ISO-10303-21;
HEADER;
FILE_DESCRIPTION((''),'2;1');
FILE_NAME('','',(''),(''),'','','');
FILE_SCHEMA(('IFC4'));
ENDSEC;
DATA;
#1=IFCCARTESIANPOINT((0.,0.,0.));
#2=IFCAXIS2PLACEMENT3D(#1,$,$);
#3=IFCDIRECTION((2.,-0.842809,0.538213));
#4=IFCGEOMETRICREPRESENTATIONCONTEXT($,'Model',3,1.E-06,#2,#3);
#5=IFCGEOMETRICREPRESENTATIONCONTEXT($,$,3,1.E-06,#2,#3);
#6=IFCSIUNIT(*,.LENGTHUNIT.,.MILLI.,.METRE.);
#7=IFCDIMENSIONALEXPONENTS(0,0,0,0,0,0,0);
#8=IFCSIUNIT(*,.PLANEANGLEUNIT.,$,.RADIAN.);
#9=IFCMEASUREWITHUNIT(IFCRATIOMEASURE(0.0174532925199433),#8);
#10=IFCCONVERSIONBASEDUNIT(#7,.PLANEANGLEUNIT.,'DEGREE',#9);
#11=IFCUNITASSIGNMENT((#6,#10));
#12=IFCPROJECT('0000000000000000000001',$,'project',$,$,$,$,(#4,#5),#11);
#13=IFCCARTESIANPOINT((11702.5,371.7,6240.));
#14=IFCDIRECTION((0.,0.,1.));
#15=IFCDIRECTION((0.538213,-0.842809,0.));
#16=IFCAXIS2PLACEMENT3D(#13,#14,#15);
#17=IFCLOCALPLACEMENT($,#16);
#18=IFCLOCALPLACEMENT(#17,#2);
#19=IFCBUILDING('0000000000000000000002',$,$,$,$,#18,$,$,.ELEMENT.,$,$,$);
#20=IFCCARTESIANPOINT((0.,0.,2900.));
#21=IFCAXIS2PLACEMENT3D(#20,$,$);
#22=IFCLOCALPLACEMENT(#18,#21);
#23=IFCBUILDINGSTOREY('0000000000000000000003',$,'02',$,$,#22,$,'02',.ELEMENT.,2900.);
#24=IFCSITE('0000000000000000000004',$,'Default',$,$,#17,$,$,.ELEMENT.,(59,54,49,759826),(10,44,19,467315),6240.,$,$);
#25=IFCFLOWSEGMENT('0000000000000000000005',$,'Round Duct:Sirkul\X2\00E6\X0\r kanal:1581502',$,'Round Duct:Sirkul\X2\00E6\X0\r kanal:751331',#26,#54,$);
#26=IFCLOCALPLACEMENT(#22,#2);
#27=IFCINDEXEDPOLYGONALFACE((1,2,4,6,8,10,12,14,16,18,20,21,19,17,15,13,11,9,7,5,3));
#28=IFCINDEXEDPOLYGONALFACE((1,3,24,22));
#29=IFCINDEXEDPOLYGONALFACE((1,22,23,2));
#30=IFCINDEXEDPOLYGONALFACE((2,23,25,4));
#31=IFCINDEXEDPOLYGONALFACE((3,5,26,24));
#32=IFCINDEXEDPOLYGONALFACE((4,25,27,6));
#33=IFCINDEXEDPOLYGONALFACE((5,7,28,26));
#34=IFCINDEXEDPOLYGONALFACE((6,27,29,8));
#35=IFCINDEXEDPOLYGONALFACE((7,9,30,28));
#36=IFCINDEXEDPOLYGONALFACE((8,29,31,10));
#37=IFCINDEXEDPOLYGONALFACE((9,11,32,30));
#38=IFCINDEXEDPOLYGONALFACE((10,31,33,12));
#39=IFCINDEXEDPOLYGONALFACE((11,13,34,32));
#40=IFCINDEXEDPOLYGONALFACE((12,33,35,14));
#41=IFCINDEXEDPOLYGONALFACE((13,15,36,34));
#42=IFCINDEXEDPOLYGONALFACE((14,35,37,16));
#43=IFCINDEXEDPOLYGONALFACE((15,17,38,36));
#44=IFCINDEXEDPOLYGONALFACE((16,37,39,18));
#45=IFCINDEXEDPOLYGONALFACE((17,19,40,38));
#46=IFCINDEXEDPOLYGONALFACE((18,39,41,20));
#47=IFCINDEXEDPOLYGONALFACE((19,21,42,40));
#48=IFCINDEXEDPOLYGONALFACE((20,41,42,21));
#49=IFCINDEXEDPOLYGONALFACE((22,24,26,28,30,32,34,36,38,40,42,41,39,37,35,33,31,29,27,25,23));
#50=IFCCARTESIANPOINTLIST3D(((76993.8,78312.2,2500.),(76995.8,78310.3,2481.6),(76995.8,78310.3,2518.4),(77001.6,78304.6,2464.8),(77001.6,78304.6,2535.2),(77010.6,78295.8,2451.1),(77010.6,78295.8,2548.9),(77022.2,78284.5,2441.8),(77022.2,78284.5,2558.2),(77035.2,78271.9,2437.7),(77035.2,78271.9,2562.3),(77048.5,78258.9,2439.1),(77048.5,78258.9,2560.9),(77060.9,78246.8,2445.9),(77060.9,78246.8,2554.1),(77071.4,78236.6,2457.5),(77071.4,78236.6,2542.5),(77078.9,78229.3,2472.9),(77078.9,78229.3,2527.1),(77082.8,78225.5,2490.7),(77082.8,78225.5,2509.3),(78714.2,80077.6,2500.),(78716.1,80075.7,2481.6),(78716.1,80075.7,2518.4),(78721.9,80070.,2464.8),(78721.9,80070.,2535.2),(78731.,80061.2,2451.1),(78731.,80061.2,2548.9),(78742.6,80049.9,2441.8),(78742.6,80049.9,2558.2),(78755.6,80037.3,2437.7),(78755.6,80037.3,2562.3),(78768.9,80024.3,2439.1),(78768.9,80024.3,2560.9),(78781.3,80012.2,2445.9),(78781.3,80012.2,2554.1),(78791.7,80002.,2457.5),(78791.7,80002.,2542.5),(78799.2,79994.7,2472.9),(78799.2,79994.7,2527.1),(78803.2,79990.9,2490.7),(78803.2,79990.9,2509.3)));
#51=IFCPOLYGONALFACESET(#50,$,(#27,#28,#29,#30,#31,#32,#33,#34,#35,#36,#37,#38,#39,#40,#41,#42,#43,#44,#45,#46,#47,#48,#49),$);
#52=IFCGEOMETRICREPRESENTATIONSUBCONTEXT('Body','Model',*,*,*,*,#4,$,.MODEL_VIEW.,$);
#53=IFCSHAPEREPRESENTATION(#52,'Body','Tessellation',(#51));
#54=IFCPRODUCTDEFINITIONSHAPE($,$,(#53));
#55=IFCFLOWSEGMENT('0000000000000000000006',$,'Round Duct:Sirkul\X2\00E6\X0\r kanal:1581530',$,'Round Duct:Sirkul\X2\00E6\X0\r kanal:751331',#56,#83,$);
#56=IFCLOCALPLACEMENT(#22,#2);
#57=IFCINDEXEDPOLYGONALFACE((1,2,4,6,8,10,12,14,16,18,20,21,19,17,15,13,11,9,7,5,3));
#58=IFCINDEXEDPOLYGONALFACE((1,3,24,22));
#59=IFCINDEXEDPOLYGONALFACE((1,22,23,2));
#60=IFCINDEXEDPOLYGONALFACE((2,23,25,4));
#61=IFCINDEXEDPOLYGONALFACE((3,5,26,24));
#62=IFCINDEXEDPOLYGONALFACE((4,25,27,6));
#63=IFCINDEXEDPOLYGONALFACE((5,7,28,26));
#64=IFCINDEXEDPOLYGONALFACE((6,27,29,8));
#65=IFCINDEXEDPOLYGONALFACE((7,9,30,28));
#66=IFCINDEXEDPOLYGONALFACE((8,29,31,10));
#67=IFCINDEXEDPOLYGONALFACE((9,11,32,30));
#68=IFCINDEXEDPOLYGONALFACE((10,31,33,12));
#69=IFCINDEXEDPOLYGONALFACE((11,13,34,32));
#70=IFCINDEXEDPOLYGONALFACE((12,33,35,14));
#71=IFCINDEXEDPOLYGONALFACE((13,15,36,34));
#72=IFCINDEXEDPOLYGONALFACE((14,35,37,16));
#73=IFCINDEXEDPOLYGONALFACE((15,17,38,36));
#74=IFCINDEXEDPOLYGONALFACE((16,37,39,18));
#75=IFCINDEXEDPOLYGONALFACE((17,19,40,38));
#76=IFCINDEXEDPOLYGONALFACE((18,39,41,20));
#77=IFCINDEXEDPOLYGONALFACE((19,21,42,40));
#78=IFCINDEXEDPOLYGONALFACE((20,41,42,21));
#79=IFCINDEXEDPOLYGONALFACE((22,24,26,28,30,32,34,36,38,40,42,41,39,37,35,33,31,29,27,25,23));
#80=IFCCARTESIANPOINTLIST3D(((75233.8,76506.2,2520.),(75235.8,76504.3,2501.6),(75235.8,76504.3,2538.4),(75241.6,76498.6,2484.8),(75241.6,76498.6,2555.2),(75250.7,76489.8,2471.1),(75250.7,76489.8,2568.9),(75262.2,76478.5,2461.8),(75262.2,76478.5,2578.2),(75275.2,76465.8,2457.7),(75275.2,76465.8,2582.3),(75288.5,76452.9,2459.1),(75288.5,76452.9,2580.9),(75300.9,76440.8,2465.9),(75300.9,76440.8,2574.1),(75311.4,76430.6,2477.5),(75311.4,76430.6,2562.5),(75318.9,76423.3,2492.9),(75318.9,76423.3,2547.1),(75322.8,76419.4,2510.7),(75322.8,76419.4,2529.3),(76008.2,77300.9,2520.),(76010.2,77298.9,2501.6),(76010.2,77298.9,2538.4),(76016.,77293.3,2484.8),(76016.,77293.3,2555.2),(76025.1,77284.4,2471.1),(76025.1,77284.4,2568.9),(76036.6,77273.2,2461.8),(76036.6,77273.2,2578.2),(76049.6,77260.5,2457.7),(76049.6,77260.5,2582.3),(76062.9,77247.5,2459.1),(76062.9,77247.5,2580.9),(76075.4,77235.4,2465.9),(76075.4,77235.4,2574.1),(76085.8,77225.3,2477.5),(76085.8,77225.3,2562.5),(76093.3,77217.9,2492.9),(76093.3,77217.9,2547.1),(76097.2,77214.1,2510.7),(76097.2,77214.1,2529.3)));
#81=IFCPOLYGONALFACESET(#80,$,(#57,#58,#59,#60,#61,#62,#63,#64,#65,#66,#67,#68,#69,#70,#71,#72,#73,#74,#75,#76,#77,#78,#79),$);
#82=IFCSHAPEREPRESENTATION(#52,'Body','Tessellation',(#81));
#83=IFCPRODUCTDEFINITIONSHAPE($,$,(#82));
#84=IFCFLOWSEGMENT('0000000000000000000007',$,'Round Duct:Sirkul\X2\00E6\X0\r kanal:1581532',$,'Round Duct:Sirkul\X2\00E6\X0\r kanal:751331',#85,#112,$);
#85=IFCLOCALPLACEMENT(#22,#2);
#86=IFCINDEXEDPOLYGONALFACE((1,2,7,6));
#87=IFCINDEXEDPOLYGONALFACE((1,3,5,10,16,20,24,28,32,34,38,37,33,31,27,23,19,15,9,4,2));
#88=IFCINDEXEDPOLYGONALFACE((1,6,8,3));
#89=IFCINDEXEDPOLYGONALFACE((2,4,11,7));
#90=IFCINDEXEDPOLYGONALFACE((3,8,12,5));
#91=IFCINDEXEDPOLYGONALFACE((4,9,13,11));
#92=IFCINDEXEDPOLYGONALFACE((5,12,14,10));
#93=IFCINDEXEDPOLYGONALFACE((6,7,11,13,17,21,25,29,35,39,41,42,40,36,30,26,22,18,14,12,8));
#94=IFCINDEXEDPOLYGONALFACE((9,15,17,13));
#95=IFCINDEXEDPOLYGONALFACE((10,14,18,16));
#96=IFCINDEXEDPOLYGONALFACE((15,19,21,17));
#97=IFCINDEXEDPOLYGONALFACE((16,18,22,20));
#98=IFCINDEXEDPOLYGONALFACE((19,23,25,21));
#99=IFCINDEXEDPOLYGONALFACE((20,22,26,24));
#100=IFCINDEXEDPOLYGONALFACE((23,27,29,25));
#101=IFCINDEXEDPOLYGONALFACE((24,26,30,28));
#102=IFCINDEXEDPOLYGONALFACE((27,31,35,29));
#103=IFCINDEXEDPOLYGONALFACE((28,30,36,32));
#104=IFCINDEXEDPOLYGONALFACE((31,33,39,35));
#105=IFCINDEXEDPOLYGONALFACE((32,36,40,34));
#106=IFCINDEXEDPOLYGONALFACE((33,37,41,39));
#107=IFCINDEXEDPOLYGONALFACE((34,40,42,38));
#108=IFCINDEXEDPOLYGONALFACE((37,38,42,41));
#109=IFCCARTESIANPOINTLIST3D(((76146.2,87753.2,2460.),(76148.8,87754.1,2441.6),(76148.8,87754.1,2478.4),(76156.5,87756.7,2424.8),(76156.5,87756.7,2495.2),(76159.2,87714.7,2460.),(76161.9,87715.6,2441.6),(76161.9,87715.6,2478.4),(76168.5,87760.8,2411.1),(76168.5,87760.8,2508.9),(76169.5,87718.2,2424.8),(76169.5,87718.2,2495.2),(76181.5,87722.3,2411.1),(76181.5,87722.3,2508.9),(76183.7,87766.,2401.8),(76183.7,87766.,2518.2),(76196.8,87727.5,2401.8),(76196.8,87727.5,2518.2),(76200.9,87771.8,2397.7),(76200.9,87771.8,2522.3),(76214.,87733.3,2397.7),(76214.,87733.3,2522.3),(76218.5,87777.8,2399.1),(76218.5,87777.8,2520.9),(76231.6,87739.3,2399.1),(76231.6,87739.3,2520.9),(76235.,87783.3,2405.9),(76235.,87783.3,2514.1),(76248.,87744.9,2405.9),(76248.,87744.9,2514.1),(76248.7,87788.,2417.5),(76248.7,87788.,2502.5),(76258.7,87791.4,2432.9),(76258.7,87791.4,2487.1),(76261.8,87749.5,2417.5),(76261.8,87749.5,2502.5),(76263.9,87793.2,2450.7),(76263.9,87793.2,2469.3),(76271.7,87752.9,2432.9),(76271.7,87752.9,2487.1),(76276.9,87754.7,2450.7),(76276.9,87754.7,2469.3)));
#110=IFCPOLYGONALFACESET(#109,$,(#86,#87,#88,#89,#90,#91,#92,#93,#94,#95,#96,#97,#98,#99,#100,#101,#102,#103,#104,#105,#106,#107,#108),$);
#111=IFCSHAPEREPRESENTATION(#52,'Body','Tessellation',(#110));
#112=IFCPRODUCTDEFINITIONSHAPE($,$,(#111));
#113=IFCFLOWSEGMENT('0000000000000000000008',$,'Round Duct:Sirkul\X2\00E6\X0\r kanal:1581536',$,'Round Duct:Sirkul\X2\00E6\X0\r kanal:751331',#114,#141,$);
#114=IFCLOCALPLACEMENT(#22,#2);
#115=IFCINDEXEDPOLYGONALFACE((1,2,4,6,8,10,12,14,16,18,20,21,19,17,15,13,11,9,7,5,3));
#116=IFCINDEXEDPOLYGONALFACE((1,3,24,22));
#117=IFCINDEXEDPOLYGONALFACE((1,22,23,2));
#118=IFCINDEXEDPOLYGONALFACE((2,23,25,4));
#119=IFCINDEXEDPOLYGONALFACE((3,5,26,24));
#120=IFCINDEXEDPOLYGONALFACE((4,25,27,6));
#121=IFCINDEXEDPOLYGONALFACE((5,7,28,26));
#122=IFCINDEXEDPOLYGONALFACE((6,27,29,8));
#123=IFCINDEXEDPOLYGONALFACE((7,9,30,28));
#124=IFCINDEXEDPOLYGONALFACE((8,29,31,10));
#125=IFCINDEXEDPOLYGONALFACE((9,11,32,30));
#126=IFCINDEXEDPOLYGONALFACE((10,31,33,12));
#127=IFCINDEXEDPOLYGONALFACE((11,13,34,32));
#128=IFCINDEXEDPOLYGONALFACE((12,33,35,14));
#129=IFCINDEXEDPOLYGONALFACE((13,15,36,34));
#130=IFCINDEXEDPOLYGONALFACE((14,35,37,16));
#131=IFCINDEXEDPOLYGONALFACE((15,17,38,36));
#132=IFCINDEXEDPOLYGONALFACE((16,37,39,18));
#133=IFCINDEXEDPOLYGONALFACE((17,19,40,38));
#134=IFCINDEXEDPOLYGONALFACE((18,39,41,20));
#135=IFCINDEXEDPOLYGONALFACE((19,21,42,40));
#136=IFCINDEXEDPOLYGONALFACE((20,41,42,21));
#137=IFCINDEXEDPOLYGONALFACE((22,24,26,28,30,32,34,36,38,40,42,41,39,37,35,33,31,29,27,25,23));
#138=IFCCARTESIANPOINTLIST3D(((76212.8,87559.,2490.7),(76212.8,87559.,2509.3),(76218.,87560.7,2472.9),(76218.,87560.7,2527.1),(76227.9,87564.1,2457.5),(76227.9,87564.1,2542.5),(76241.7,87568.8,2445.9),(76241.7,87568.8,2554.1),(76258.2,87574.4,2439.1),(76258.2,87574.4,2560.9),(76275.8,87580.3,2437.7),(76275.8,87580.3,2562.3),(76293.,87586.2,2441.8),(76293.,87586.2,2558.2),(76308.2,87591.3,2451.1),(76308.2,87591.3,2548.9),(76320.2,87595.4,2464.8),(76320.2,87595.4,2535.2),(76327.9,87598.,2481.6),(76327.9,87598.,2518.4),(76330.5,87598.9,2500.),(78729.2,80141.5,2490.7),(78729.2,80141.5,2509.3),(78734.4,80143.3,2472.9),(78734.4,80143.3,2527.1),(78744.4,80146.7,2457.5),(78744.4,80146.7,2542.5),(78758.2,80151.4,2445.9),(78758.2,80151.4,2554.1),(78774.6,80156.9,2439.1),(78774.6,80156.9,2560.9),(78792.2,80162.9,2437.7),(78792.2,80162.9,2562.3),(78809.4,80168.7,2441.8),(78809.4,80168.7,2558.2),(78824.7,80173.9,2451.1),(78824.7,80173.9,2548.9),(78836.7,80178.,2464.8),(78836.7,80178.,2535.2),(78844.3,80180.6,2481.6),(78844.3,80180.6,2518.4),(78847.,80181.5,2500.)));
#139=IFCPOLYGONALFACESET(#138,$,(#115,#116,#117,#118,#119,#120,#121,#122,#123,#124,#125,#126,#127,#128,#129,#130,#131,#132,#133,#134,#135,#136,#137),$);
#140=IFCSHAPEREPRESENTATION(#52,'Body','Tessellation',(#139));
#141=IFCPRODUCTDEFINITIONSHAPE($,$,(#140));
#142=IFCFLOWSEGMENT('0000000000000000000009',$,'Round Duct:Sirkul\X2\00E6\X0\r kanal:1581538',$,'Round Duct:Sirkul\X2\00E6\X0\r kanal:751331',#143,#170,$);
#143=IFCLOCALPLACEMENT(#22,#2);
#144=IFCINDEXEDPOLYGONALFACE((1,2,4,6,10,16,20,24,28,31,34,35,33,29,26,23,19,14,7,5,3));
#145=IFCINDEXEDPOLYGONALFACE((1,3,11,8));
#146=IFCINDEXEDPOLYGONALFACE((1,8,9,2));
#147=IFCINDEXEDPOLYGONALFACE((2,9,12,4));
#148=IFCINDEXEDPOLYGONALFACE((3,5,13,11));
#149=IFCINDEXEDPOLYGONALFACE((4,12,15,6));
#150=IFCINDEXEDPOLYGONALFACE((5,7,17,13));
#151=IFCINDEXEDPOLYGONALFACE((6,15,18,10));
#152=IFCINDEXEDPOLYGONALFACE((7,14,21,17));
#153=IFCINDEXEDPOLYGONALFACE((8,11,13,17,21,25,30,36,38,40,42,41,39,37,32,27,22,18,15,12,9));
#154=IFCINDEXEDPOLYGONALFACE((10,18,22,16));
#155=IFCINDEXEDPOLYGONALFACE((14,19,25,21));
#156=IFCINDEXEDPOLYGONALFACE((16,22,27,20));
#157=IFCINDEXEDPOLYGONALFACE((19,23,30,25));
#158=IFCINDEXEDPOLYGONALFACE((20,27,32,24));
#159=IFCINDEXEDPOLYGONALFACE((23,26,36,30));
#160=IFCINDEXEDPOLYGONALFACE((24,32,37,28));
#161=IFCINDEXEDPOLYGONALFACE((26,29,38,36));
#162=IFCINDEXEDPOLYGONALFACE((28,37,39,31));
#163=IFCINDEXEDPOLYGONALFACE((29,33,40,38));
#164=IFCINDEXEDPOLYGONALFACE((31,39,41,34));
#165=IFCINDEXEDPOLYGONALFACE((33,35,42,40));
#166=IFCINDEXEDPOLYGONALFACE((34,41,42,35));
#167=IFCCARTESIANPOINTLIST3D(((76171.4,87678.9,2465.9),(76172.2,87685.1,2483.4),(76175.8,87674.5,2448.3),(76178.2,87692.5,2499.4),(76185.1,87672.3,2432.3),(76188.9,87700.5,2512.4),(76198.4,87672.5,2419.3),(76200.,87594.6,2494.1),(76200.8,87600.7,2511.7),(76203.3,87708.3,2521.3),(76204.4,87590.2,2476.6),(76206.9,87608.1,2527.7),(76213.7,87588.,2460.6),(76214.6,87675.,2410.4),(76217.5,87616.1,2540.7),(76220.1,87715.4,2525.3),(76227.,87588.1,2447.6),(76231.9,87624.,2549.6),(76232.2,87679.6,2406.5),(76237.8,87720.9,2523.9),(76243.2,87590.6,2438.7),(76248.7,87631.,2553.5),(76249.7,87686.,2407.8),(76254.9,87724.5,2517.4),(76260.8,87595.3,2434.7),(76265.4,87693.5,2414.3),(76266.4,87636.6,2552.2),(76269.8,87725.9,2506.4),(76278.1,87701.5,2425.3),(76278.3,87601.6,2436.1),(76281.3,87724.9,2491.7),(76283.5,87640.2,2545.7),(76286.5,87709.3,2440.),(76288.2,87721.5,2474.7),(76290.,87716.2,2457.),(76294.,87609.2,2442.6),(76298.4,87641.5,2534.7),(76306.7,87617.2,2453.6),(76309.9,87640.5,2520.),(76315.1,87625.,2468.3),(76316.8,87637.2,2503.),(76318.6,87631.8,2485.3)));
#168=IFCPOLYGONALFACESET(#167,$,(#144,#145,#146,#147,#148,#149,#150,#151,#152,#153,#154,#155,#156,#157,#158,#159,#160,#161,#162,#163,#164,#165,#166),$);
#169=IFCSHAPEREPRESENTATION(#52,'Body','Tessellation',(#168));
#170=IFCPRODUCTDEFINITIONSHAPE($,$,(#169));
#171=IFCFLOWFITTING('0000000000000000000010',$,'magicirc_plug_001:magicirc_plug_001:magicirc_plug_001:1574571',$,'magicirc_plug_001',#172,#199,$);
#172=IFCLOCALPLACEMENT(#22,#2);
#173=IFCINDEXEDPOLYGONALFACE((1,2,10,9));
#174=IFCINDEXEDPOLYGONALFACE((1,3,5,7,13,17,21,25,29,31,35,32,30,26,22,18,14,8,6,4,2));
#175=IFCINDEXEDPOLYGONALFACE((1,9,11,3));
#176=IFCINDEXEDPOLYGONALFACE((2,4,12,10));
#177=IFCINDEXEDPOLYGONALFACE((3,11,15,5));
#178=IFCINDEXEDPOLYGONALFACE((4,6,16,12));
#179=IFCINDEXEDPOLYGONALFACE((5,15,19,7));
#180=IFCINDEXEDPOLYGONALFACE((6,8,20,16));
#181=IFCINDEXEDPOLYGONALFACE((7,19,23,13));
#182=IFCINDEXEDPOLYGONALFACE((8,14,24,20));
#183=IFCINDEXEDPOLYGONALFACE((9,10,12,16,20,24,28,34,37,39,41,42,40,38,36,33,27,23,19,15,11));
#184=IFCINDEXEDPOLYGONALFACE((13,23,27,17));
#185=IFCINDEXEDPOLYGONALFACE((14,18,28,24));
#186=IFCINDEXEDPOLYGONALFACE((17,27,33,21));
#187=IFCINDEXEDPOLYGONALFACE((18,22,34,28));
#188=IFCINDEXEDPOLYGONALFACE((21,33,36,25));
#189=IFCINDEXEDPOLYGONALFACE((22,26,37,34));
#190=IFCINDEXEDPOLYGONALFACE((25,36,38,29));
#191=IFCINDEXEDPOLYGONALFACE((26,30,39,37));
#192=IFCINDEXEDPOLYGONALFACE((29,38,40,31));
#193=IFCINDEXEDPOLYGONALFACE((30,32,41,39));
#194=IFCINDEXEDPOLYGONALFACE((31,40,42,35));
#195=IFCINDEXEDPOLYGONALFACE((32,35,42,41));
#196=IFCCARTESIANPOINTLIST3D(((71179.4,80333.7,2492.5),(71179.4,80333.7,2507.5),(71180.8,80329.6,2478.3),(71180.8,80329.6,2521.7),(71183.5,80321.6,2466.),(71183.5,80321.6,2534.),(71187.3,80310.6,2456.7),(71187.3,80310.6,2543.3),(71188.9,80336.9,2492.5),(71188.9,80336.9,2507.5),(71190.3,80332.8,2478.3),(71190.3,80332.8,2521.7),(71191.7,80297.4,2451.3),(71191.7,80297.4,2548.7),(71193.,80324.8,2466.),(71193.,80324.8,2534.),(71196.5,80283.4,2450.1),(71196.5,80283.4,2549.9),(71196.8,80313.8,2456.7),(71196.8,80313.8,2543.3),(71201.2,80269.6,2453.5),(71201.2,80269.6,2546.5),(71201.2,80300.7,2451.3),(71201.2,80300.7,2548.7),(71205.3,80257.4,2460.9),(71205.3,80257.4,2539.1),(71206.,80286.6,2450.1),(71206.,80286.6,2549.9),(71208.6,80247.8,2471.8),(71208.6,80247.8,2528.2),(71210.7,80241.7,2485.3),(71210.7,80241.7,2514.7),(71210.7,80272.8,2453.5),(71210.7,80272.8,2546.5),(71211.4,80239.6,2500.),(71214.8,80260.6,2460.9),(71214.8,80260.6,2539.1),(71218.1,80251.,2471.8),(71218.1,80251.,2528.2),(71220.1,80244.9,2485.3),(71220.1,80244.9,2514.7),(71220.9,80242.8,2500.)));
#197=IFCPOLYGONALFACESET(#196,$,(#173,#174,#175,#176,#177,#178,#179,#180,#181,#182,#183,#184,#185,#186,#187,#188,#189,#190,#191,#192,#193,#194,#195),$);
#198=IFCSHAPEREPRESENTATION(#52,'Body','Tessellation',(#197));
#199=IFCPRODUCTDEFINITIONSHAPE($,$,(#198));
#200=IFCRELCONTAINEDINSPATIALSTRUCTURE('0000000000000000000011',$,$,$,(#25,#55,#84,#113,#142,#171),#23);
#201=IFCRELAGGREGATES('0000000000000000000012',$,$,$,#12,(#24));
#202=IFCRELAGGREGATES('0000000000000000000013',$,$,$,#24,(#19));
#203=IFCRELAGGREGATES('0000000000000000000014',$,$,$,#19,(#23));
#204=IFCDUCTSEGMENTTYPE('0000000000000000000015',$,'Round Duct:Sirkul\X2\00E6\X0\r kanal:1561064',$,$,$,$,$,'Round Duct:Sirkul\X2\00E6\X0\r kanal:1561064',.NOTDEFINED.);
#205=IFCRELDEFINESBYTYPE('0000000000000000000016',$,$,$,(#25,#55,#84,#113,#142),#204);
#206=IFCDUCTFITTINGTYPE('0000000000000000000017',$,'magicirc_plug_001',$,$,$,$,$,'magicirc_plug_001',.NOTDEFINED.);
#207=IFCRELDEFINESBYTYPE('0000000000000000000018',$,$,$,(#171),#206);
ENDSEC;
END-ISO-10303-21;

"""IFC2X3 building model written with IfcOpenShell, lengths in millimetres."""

from ifc_helpers import new_model, entity, si_unit, converted_unit, direction, frame, frame_2d, origin, origin_2d_with_axis, place, context, subcontext, project, spatial, circle, extrude, source, transform, mapped, type_object, type_shapes, element, save


model = new_model("IFC2X3")

# Units and contexts
model_context = context("Model", 3, precision=1e-06, world=origin(), true_north=direction((2.0, -0.842809, 0.538213)))
context_of_model = context(None, 3, precision=1e-06, world=origin(), true_north=direction((2.0, -0.842809, 0.538213)))
body_context = subcontext(model_context, "Body", "Model", "MODEL_VIEW")
ifc_project = project(units=[si_unit("LENGTHUNIT", "METRE", prefix="MILLI"), converted_unit("PLANEANGLEUNIT", "DEGREE", entity("IfcRatioMeasure", 0.0174532925199433), si_unit("PLANEANGLEUNIT", "RADIAN"), dimensions=[0, 0, 0, 0, 0, 0, 0])], contexts=[model_context, context_of_model])

# Site, building, storey
site_placement = place(None, frame((11702.5, 371.7, 6240.0), z_axis=(0.0, 0.0, 1.0), x_axis=(0.538213, -0.842809, 0.0)))
site = spatial("IfcSite", under=ifc_project, at=site_placement, Name="Default", CompositionType="ELEMENT", RefLatitude=(59, 54, 49, 759826), RefLongitude=(10, 44, 19, 467315), RefElevation=6240.0)
building_placement = place(site_placement, origin())
building = spatial("IfcBuilding", under=site, at=building_placement, CompositionType="ELEMENT")
storey_placement = place(building_placement, frame((0.0, 0.0, 2900.0)))
storey = spatial("IfcBuildingStorey", under=building, at=storey_placement, Name="02", LongName="02", CompositionType="ELEMENT", Elevation=2900.0)

# Flow segments
duct_segment_type = type_object("IfcDuctSegmentType", Name="Round Duct:Sirkulær kanal:1561064", ElementType="Round Duct:Sirkulær kanal:1561064", PredefinedType="NOTDEFINED")
flow_segment_1_placement = place(storey_placement, origin())
element("IfcFlowSegment", 1, at=flow_segment_1_placement, inside=storey, type_object=duct_segment_type, Name="Round Duct:Sirkulær kanal:1581502", ObjectType="Round Duct:Sirkulær kanal:751331", context=body_context, shape_type="SweptSolid", body=[
    extrude(circle(Radius=62.5, at=frame_2d((0.0, 0.0), x_axis=(1.0, 0.0))), frame((77038.5, 78268.6, 2500.0), z_axis=(0.697915, 0.71618, 0.0), x_axis=(-0.71618, 0.697915, 0.0)), (0.0, 0.0, 1.0), 2465.0),
])
flow_segment_2_placement = place(storey_placement, origin())
element("IfcFlowSegment", 2, at=flow_segment_2_placement, inside=storey, type_object=duct_segment_type, Name="Round Duct:Sirkulær kanal:1581530", ObjectType="Round Duct:Sirkulær kanal:751331", context=body_context, shape_type="SweptSolid", body=[
    extrude(circle(Radius=62.5, at=origin_2d_with_axis()), frame((75278.6, 76462.6, 2520.0), z_axis=(0.697915, 0.71618, 0.0), x_axis=(-0.71618, 0.697915, 0.0)), (0.0, 0.0, 1.0), 1109.6),
])
flow_segment_3_placement = place(storey_placement, origin())
element("IfcFlowSegment", 3, at=flow_segment_3_placement, inside=storey, type_object=duct_segment_type, Name="Round Duct:Sirkulær kanal:1581532", ObjectType="Round Duct:Sirkulær kanal:751331", context=body_context, shape_type="SweptSolid", body=[
    extrude(circle(Radius=62.5, at=origin_2d_with_axis()), frame((76218.4, 87734.8, 2460.0), z_axis=(-0.321245, 0.946996, 0.0), x_axis=(-0.946996, -0.321245, 0.0)), (0.0, 0.0, 1.0), 40.6),
])
flow_segment_4_placement = place(storey_placement, origin())
element("IfcFlowSegment", 4, at=flow_segment_4_placement, inside=storey, type_object=duct_segment_type, Name="Round Duct:Sirkulær kanal:1581536", ObjectType="Round Duct:Sirkulær kanal:751331", context=body_context, shape_type="SweptSolid", body=[
    extrude(circle(Radius=62.5, at=origin_2d_with_axis()), frame((76271.3, 87578.8, 2500.0), z_axis=(0.321274, -0.946986, 0.0), x_axis=(0.946986, 0.321274, 0.0)), (0.0, 0.0, 1.0), 7832.7),
])
flow_segment_5_placement = place(storey_placement, origin())
element("IfcFlowSegment", 5, at=flow_segment_5_placement, inside=storey, type_object=duct_segment_type, Name="Round Duct:Sirkulær kanal:1581538", ObjectType="Round Duct:Sirkulær kanal:751331", context=body_context, shape_type="SweptSolid", body=[
    extrude(circle(Radius=62.5, at=frame_2d((0.0, 0.0), x_axis=(1.0, 0.0))), frame((76230.6, 87699.0, 2465.9), z_axis=(0.306214, -0.902596, 0.302579), x_axis=(-0.946986, -0.321274, 0.0)), (0.0, 0.0, 1.0), 93.5),
])

# Flow fitting
duct_fitting_type_1 = type_object("IfcDuctFittingType", Name="magicirc_plug_001", ElementType="magicirc_plug_001", PredefinedType="NOTDEFINED")
shared_shape_1 = source(origin(), body_context, "Body", "SweptSolid", [
    extrude(circle(Radius=50.0, at=frame_2d((0.0, 0.0), x_axis=(1.0, 0.0))), frame((0.0, 0.0, 0.0), z_axis=(1.0, 0.0, 0.0), x_axis=(0.0, 1.0, 0.0)), (0.0, 0.0, 1.0), 10.0),
])
type_shapes(duct_fitting_type_1, [shared_shape_1])
flow_fitting_placement = place(storey_placement, frame((71204.8, 80290.1, 2500.0), z_axis=(0.0, 0.0, 1.0), x_axis=(-0.946986, -0.321274, 0.0)))
element("IfcFlowFitting", 6, at=flow_fitting_placement, inside=storey, type_object=duct_fitting_type_1, Name="magicirc_plug_001:magicirc_plug_001:magicirc_plug_001:1574571", ObjectType="magicirc_plug_001", context=body_context, shape_type="MappedRepresentation", body=[
    mapped(shared_shape_1, transform((0.0, 0.0, 0.0), scale=1.0)),
])

save(model, "model.ifc")
